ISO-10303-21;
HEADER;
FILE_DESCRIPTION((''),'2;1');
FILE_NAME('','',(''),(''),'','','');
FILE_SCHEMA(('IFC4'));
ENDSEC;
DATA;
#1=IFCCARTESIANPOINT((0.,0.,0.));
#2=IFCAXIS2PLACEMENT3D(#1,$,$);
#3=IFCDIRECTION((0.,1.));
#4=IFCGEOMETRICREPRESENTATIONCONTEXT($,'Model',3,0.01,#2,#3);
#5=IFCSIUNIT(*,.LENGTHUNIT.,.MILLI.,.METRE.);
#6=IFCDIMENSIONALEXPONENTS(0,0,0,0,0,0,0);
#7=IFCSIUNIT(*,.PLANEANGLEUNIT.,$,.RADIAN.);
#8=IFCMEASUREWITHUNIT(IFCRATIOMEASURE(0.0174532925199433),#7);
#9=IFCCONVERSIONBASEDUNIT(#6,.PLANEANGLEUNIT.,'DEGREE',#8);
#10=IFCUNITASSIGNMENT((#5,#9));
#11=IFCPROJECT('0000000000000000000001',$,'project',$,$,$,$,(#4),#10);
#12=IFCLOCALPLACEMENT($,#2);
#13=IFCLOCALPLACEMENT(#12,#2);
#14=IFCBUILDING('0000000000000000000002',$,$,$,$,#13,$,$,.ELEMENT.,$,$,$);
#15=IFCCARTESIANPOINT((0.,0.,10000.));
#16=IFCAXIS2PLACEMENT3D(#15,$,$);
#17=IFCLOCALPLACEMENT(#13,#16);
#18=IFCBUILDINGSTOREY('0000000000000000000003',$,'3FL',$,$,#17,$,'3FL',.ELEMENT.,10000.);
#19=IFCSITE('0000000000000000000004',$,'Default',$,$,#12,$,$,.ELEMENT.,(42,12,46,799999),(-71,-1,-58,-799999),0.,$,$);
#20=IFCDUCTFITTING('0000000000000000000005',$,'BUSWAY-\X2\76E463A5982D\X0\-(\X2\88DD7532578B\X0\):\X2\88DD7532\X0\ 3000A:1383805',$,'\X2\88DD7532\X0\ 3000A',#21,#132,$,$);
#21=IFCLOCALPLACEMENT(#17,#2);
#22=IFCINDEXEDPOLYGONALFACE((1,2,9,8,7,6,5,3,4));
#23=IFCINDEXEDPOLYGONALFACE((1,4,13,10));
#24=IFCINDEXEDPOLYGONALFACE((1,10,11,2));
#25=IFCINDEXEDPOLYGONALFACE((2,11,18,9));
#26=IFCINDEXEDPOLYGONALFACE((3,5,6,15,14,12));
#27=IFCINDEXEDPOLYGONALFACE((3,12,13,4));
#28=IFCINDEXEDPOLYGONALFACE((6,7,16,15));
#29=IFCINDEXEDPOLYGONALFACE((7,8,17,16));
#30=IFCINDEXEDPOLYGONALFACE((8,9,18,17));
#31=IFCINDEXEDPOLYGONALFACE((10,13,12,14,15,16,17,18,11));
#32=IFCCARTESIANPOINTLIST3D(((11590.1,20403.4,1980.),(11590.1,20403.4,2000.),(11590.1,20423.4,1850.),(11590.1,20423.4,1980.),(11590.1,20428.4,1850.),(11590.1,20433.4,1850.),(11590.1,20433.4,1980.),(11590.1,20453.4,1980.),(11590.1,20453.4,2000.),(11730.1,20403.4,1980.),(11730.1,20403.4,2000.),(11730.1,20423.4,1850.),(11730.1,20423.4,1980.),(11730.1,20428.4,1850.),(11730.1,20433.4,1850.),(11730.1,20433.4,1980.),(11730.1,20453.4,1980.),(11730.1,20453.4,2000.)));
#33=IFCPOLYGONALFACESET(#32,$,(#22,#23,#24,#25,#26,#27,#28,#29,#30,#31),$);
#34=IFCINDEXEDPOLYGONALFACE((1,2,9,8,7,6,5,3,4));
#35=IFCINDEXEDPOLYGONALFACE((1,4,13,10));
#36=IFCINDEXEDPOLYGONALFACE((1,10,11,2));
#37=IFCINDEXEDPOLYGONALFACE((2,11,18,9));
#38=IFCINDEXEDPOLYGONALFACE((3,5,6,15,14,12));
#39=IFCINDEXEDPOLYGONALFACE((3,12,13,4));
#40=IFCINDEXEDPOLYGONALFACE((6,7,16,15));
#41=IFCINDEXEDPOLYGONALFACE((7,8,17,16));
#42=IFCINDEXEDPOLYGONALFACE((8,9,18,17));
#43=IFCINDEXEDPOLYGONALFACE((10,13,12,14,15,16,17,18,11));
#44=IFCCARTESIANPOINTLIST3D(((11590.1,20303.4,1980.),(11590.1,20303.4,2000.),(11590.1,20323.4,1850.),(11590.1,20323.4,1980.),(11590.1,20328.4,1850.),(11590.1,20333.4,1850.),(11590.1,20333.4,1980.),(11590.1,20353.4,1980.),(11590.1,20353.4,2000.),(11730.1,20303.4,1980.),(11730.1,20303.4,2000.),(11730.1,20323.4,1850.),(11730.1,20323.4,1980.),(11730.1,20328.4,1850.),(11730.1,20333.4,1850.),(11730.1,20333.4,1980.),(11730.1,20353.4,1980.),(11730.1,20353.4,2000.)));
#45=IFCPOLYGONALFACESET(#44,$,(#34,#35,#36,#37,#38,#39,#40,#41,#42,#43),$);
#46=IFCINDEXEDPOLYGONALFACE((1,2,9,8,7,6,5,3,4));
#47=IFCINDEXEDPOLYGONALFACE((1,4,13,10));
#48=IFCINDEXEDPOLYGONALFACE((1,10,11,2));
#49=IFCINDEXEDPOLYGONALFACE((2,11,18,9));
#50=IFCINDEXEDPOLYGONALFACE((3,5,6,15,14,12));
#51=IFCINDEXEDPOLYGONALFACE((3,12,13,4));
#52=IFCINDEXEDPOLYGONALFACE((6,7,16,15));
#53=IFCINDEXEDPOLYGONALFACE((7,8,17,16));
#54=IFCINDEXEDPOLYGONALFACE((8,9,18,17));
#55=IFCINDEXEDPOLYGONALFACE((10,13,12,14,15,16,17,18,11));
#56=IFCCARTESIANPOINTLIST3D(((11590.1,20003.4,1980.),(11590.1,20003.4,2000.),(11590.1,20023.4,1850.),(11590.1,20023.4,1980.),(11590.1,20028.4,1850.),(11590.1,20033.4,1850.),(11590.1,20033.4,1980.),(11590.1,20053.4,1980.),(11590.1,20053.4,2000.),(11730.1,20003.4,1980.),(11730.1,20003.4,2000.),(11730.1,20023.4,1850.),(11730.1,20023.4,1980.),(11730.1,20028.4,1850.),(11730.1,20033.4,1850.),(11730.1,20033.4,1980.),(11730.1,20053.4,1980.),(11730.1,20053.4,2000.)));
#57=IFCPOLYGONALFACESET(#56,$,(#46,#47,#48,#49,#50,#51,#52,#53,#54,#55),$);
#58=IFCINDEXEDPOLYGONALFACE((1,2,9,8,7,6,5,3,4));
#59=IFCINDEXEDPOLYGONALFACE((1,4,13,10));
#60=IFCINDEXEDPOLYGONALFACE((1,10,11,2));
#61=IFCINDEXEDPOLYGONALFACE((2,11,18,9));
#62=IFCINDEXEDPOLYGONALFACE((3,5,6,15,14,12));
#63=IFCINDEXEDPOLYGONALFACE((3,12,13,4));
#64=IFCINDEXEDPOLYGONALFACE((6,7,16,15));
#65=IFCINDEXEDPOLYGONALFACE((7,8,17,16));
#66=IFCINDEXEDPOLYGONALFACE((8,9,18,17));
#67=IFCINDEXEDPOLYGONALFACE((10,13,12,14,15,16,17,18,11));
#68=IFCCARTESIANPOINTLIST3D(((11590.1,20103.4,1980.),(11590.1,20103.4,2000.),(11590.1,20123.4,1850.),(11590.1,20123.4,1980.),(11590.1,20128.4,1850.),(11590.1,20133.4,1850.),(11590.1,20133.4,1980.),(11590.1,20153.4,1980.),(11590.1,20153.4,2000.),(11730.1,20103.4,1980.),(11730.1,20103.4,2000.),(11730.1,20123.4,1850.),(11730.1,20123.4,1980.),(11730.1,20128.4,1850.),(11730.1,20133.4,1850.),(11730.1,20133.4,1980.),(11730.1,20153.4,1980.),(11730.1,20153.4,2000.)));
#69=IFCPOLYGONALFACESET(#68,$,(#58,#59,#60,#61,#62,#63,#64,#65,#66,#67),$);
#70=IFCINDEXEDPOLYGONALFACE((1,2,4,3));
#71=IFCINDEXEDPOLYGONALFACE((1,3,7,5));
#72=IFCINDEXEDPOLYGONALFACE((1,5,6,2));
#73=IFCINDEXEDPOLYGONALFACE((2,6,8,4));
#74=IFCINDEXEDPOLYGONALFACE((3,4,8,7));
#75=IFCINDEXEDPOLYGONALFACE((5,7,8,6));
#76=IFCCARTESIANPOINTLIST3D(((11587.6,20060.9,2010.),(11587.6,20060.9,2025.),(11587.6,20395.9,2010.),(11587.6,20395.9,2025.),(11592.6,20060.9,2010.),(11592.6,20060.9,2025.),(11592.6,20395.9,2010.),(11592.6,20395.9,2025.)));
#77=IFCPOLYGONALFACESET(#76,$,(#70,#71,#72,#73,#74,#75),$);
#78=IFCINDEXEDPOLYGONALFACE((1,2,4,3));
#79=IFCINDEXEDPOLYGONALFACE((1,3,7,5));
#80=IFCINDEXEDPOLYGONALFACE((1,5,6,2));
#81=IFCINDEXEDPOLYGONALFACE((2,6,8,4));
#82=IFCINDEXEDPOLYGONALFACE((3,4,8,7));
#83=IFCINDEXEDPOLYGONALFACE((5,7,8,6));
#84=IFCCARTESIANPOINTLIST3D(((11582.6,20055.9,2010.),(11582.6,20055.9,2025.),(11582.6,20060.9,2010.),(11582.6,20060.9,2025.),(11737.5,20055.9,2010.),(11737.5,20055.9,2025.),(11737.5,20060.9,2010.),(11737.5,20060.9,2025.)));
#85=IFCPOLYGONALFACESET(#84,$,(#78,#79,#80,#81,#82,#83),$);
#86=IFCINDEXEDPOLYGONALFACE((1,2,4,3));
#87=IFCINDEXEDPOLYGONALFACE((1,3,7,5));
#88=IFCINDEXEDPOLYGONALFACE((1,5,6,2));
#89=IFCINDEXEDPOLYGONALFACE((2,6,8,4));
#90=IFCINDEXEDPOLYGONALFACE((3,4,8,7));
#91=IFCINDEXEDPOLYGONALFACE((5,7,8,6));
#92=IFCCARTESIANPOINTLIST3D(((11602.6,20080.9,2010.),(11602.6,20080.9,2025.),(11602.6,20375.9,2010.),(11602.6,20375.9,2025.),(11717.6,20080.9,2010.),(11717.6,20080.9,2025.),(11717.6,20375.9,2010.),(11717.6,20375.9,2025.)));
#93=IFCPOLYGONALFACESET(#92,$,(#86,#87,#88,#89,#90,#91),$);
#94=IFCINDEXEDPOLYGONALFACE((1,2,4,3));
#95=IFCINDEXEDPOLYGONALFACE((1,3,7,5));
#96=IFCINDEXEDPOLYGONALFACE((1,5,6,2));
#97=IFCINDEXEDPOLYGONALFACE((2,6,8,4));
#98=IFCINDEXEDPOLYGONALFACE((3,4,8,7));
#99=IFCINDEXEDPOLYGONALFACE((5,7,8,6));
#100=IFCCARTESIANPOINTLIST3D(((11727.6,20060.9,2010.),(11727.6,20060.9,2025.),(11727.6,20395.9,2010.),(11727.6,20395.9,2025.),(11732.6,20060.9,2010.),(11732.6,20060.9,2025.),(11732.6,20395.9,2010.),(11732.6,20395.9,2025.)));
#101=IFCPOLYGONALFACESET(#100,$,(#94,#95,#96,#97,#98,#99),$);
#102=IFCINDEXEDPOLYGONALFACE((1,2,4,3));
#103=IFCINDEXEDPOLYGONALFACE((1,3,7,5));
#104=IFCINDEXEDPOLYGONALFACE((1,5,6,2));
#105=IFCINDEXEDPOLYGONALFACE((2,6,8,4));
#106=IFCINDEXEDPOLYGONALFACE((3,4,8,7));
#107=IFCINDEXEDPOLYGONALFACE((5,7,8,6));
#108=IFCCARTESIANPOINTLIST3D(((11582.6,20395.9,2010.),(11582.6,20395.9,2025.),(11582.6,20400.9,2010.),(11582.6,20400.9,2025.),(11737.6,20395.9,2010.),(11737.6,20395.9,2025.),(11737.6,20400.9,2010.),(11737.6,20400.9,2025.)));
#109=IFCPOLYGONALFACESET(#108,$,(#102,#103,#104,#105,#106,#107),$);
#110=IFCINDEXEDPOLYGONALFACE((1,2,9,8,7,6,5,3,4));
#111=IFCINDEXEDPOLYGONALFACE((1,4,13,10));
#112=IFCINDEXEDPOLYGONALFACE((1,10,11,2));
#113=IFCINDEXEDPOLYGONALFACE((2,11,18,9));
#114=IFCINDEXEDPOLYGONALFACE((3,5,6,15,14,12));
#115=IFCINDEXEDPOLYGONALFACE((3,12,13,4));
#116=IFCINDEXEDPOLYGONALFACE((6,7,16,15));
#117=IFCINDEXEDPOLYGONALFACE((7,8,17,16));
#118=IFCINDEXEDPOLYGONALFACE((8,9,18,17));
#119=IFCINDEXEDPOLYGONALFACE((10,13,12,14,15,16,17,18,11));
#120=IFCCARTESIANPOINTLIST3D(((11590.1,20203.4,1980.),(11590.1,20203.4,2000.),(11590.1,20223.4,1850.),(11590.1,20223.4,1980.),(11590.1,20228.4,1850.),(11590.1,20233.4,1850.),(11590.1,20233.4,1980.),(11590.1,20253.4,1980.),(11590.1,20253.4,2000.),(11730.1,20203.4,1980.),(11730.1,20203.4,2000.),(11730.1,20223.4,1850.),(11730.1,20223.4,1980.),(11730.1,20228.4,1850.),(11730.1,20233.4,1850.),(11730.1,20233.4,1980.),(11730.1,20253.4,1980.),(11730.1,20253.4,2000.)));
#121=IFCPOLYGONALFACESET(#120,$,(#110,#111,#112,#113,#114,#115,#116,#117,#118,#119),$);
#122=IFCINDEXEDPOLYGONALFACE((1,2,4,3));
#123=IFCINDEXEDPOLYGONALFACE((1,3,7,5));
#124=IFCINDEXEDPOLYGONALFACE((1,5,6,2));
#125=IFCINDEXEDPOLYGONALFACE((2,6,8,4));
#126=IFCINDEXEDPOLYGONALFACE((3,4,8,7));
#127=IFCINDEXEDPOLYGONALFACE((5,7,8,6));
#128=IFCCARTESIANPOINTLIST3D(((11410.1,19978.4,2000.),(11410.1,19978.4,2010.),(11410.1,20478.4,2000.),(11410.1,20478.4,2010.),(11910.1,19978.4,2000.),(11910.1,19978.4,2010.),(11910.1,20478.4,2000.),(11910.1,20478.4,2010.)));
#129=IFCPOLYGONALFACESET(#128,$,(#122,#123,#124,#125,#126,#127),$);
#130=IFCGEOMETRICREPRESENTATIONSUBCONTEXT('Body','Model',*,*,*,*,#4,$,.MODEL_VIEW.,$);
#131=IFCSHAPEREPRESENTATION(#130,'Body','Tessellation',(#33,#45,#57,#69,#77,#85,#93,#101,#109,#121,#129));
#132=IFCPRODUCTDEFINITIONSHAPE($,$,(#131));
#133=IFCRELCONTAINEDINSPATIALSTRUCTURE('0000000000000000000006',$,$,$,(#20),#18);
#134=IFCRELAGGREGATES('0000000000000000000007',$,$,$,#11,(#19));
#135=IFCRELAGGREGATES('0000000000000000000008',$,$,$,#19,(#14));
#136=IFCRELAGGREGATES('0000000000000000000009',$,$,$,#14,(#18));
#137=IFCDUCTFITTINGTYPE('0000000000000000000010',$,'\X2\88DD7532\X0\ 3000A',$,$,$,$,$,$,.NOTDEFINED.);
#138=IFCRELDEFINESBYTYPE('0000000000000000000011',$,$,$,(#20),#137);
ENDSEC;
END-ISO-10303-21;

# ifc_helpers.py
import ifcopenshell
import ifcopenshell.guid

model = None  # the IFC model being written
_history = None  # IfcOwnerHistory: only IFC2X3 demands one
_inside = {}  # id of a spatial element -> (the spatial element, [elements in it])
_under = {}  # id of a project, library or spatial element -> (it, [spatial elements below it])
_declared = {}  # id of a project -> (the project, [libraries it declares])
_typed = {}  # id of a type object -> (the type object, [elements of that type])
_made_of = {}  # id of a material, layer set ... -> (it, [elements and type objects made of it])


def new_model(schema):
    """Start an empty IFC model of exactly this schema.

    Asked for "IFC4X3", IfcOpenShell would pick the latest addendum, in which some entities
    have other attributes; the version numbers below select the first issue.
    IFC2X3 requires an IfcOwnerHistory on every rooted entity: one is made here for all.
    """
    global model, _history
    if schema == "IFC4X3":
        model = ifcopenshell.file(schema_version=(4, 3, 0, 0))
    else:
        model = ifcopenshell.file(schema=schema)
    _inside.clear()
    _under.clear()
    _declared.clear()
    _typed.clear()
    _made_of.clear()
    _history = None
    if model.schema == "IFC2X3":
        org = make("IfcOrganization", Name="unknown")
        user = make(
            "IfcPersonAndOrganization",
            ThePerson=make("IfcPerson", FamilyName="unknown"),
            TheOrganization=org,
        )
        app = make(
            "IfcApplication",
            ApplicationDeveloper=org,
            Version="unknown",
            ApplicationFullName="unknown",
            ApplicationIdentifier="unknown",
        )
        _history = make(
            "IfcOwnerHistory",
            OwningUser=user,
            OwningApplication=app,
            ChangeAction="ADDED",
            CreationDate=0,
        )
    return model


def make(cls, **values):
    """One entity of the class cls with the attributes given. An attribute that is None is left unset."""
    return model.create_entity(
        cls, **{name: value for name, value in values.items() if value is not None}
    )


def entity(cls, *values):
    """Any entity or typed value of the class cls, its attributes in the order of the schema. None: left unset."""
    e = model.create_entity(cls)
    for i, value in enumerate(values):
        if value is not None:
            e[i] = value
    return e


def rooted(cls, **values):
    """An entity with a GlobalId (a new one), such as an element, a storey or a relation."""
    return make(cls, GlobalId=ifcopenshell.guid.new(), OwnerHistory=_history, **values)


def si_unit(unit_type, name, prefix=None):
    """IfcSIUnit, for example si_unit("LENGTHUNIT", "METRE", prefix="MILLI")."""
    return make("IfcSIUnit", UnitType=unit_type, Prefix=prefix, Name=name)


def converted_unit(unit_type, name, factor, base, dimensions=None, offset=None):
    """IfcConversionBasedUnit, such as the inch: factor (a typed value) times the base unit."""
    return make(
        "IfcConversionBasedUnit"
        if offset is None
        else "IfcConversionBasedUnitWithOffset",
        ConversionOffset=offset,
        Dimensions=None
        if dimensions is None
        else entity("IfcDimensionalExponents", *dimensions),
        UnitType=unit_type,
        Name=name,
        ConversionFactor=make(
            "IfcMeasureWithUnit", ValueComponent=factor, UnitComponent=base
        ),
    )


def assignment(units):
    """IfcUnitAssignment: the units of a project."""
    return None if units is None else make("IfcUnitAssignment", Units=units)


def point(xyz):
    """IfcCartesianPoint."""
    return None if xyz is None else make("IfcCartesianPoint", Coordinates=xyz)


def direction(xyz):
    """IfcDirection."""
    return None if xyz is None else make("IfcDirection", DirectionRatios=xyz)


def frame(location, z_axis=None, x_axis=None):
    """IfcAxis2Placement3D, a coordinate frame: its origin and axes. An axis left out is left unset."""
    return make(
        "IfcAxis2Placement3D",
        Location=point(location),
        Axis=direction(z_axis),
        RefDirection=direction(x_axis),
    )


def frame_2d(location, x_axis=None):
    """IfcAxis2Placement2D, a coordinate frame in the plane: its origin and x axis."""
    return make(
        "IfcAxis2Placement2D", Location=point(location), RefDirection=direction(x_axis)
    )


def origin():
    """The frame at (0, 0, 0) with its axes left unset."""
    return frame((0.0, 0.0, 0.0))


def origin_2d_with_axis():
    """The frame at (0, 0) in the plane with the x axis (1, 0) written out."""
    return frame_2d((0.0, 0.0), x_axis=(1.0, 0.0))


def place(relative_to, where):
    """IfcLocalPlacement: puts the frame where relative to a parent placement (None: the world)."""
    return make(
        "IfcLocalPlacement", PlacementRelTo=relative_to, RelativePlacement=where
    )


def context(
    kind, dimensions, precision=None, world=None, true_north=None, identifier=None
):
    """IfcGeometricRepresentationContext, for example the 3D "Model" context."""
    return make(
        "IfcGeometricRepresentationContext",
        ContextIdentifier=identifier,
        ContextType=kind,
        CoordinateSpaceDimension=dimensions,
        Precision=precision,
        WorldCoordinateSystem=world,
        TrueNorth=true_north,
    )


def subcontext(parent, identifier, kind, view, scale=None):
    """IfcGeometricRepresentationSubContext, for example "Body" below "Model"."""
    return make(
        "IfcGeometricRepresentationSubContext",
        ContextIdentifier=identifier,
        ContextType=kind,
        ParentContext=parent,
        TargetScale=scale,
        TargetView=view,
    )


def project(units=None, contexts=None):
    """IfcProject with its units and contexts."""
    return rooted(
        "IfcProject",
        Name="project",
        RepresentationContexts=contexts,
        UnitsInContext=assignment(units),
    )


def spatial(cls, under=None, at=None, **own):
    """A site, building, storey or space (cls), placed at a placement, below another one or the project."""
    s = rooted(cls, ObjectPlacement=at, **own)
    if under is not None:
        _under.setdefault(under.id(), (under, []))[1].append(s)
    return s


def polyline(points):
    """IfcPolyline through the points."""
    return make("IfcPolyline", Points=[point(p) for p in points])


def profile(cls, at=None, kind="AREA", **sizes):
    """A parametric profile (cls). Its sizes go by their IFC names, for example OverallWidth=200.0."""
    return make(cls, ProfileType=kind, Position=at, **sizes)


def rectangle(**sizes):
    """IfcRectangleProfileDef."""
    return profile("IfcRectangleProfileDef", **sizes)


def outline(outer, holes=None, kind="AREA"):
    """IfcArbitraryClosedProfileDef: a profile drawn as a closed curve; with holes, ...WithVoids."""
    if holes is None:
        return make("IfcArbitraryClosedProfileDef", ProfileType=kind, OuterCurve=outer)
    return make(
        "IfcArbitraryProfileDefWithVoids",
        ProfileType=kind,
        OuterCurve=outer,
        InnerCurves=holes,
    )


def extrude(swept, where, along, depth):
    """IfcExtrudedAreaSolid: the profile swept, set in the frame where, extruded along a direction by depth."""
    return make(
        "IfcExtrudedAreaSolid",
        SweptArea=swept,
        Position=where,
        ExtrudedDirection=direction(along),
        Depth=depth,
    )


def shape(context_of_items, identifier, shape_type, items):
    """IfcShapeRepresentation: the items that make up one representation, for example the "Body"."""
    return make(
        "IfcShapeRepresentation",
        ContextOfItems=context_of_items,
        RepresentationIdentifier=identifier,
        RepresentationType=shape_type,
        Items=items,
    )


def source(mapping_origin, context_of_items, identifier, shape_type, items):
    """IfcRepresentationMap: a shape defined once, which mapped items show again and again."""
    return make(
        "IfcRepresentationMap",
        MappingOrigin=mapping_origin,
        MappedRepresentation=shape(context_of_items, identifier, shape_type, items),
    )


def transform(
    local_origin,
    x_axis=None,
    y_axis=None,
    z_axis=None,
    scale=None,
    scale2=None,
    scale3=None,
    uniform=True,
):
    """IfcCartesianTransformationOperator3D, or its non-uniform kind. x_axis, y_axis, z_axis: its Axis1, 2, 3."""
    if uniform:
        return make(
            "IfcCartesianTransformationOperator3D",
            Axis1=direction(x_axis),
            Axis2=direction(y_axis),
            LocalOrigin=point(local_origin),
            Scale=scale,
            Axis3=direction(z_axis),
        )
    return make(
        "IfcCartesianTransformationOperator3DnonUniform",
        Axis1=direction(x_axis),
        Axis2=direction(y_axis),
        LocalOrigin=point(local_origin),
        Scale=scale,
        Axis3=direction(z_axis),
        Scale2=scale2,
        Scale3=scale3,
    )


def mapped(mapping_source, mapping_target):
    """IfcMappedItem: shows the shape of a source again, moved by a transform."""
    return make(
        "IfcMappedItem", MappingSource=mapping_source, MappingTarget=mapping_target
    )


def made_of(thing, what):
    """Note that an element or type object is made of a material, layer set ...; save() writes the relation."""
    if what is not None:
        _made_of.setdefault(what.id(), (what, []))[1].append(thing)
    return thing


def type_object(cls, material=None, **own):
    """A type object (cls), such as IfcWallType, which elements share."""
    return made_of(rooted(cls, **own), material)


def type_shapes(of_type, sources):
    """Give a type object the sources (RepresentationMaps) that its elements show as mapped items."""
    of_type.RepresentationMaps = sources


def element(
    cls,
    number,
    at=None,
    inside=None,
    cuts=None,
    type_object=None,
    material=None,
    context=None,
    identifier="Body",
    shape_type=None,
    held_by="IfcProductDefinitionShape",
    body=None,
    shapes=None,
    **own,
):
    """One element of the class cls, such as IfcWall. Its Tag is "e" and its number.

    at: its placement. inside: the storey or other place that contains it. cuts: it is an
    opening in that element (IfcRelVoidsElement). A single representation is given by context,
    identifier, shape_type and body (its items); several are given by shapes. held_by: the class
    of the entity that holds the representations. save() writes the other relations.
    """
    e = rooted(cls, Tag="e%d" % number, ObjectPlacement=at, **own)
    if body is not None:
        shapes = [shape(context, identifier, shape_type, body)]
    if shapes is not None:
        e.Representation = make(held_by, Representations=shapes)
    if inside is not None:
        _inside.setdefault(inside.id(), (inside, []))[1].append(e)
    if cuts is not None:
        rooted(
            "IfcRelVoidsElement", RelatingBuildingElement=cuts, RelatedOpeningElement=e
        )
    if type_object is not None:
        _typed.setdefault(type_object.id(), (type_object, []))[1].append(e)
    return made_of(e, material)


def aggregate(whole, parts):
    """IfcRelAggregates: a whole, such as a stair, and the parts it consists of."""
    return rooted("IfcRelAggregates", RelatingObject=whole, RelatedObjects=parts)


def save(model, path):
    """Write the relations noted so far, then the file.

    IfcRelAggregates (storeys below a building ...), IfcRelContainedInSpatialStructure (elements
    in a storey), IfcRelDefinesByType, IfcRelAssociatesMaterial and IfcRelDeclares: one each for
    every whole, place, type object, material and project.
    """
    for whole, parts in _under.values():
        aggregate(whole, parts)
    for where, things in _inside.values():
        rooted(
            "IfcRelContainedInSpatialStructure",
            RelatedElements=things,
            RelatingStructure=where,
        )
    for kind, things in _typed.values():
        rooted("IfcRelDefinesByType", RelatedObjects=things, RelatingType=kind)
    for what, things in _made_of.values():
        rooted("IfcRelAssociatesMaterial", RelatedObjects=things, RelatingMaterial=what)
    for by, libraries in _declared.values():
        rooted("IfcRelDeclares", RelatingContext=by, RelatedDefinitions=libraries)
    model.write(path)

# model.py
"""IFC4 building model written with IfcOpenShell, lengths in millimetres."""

from ifc_helpers import new_model, entity, si_unit, converted_unit, direction, frame, frame_2d, origin, origin_2d_with_axis, place, context, subcontext, project, spatial, polyline, rectangle, outline, extrude, source, transform, mapped, type_object, type_shapes, element, save


model = new_model("IFC4")

# Units and contexts
model_context = context("Model", 3, precision=0.01, world=origin(), true_north=direction((0.0, 1.0)))
body_context = subcontext(model_context, "Body", "Model", "MODEL_VIEW")
ifc_project = project(units=[si_unit("LENGTHUNIT", "METRE", prefix="MILLI"), converted_unit("PLANEANGLEUNIT", "DEGREE", entity("IfcRatioMeasure", 0.0174532925199433), si_unit("PLANEANGLEUNIT", "RADIAN"), dimensions=[0, 0, 0, 0, 0, 0, 0])], contexts=[model_context])

# Site, building, storey
site_placement = place(None, origin())
site = spatial("IfcSite", under=ifc_project, at=site_placement, Name="Default", CompositionType="ELEMENT", RefLatitude=(42, 12, 46, 799999), RefLongitude=(-71, -1, -58, -799999), RefElevation=0.0)
building_placement = place(site_placement, origin())
building = spatial("IfcBuilding", under=site, at=building_placement, CompositionType="ELEMENT")
storey_placement = place(building_placement, frame((0.0, 0.0, 10000.0)))
storey = spatial("IfcBuildingStorey", under=building, at=storey_placement, Name="3FL", LongName="3FL", CompositionType="ELEMENT", Elevation=10000.0)

# Duct fitting
duct_fitting_type_1 = type_object("IfcDuctFittingType", Name="裝甲 3000A", PredefinedType="NOTDEFINED")
shared_shape_1 = source(origin(), body_context, "Body", "SweptSolid", [
    extrude(outline(polyline([(-25.0, -58.9), (25.0, -58.9), (25.0, -38.9), (5.0, -38.9), (5.0, 91.1), (0.0, 91.1), (-5.0, 91.1), (-5.0, -38.9), (-25.0, -38.9), (-25.0, -58.9)])), frame((-200.0, -70.0, -58.9), z_axis=(0.0, 1.0, 0.0), x_axis=(1.0, 0.0, 0.0)), (0.0, 0.0, 1.0), 140.0),
    extrude(outline(polyline([(-25.0, -58.9), (25.0, -58.9), (25.0, -38.9), (5.0, -38.9), (5.0, 91.1), (0.0, 91.1), (-5.0, 91.1), (-5.0, -38.9), (-25.0, -38.9), (-25.0, -58.9)])), frame((-100.0, -70.0, -58.9), z_axis=(0.0, 1.0, 0.0), x_axis=(1.0, 0.0, 0.0)), (0.0, 0.0, 1.0), 140.0),
    extrude(outline(polyline([(-58.9, -25.0), (-38.9, -25.0), (-38.9, -5.0), (91.1, -5.0), (91.1, 0.0), (91.1, 5.0), (-38.9, 5.0), (-38.9, 25.0), (-58.9, 25.0), (-58.9, -25.0)])), frame((200.0, -70.0, -58.9), z_axis=(0.0, 1.0, 0.0), x_axis=(0.0, 0.0, -1.0)), (0.0, 0.0, 1.0), 140.0),
    extrude(outline(polyline([(-58.9, -25.0), (-38.9, -25.0), (-38.9, -5.0), (91.1, -5.0), (91.1, 0.0), (91.1, 5.0), (-38.9, 5.0), (-38.9, 25.0), (-58.9, 25.0), (-58.9, -25.0)])), frame((100.0, -70.0, -58.9), z_axis=(0.0, 1.0, 0.0), x_axis=(0.0, 0.0, -1.0)), (0.0, 0.0, 1.0), 140.0),
    extrude(rectangle(XDim=335.0, YDim=5.0, at=origin_2d_with_axis()), frame((0.0, -70.0, 10.0), z_axis=(0.0, 0.0, 1.0), x_axis=(-1.0, 0.0, 0.0)), (0.0, 0.0, 1.0), 15.0),
    extrude(rectangle(XDim=5.0, YDim=154.9, at=frame_2d((0.0, 0.0), x_axis=(1.0, 0.0))), frame((170.0, -0.1, 10.0), z_axis=(0.0, 0.0, 1.0), x_axis=(-1.0, 0.0, 0.0)), (0.0, 0.0, 1.0), 15.0),
    extrude(rectangle(XDim=295.0, YDim=115.0, at=origin_2d_with_axis()), frame((0.0, 0.0, 10.0), z_axis=(0.0, 0.0, 1.0), x_axis=(-1.0, 0.0, 0.0)), (0.0, 0.0, 1.0), 15.0),
    extrude(rectangle(XDim=335.0, YDim=5.0, at=origin_2d_with_axis()), frame((0.0, 70.0, 10.0), z_axis=(0.0, 0.0, 1.0), x_axis=(-1.0, 0.0, 0.0)), (0.0, 0.0, 1.0), 15.0),
    extrude(rectangle(XDim=5.0, YDim=155.0, at=origin_2d_with_axis()), frame((-170.0, 0.0, 10.0), z_axis=(0.0, 0.0, 1.0), x_axis=(-1.0, 0.0, 0.0)), (0.0, 0.0, 1.0), 15.0),
    extrude(outline(polyline([(-58.9, -25.0), (-38.9, -25.0), (-38.9, -5.0), (91.1, -5.0), (91.1, 0.0), (91.1, 5.0), (-38.9, 5.0), (-38.9, 25.0), (-58.9, 25.0), (-58.9, -25.0)])), frame((0.0, -70.0, -58.9), z_axis=(0.0, 1.0, 0.0), x_axis=(0.0, 0.0, -1.0)), (0.0, 0.0, 1.0), 140.0),
    extrude(rectangle(XDim=500.0, YDim=500.0, at=origin_2d_with_axis()), frame((0.0, 0.0, 0.0), z_axis=(0.0, 0.0, 1.0), x_axis=(0.0, 1.0, 0.0)), (0.0, 0.0, 1.0), 10.0),
])
type_shapes(duct_fitting_type_1, [shared_shape_1])
for number, where, z_axis, x_axis, name in (
    (1, (11660.1, 20228.4, 2000.0), (0.0, 0.0, 1.0), (0.0, -1.0, 0.0), "BUSWAY-盤接頭-(裝甲型):裝甲 3000A:1383805"),
):
    element("IfcDuctFitting", number, at=place(storey_placement, frame(where, z_axis=z_axis, x_axis=x_axis)), inside=storey, type_object=duct_fitting_type_1, Name=name, ObjectType="裝甲 3000A", context=body_context, shape_type="MappedRepresentation", body=[
        mapped(shared_shape_1, transform((0.0, 0.0, 0.0), scale=1.0)),
    ])

save(model, "model.ifc")
